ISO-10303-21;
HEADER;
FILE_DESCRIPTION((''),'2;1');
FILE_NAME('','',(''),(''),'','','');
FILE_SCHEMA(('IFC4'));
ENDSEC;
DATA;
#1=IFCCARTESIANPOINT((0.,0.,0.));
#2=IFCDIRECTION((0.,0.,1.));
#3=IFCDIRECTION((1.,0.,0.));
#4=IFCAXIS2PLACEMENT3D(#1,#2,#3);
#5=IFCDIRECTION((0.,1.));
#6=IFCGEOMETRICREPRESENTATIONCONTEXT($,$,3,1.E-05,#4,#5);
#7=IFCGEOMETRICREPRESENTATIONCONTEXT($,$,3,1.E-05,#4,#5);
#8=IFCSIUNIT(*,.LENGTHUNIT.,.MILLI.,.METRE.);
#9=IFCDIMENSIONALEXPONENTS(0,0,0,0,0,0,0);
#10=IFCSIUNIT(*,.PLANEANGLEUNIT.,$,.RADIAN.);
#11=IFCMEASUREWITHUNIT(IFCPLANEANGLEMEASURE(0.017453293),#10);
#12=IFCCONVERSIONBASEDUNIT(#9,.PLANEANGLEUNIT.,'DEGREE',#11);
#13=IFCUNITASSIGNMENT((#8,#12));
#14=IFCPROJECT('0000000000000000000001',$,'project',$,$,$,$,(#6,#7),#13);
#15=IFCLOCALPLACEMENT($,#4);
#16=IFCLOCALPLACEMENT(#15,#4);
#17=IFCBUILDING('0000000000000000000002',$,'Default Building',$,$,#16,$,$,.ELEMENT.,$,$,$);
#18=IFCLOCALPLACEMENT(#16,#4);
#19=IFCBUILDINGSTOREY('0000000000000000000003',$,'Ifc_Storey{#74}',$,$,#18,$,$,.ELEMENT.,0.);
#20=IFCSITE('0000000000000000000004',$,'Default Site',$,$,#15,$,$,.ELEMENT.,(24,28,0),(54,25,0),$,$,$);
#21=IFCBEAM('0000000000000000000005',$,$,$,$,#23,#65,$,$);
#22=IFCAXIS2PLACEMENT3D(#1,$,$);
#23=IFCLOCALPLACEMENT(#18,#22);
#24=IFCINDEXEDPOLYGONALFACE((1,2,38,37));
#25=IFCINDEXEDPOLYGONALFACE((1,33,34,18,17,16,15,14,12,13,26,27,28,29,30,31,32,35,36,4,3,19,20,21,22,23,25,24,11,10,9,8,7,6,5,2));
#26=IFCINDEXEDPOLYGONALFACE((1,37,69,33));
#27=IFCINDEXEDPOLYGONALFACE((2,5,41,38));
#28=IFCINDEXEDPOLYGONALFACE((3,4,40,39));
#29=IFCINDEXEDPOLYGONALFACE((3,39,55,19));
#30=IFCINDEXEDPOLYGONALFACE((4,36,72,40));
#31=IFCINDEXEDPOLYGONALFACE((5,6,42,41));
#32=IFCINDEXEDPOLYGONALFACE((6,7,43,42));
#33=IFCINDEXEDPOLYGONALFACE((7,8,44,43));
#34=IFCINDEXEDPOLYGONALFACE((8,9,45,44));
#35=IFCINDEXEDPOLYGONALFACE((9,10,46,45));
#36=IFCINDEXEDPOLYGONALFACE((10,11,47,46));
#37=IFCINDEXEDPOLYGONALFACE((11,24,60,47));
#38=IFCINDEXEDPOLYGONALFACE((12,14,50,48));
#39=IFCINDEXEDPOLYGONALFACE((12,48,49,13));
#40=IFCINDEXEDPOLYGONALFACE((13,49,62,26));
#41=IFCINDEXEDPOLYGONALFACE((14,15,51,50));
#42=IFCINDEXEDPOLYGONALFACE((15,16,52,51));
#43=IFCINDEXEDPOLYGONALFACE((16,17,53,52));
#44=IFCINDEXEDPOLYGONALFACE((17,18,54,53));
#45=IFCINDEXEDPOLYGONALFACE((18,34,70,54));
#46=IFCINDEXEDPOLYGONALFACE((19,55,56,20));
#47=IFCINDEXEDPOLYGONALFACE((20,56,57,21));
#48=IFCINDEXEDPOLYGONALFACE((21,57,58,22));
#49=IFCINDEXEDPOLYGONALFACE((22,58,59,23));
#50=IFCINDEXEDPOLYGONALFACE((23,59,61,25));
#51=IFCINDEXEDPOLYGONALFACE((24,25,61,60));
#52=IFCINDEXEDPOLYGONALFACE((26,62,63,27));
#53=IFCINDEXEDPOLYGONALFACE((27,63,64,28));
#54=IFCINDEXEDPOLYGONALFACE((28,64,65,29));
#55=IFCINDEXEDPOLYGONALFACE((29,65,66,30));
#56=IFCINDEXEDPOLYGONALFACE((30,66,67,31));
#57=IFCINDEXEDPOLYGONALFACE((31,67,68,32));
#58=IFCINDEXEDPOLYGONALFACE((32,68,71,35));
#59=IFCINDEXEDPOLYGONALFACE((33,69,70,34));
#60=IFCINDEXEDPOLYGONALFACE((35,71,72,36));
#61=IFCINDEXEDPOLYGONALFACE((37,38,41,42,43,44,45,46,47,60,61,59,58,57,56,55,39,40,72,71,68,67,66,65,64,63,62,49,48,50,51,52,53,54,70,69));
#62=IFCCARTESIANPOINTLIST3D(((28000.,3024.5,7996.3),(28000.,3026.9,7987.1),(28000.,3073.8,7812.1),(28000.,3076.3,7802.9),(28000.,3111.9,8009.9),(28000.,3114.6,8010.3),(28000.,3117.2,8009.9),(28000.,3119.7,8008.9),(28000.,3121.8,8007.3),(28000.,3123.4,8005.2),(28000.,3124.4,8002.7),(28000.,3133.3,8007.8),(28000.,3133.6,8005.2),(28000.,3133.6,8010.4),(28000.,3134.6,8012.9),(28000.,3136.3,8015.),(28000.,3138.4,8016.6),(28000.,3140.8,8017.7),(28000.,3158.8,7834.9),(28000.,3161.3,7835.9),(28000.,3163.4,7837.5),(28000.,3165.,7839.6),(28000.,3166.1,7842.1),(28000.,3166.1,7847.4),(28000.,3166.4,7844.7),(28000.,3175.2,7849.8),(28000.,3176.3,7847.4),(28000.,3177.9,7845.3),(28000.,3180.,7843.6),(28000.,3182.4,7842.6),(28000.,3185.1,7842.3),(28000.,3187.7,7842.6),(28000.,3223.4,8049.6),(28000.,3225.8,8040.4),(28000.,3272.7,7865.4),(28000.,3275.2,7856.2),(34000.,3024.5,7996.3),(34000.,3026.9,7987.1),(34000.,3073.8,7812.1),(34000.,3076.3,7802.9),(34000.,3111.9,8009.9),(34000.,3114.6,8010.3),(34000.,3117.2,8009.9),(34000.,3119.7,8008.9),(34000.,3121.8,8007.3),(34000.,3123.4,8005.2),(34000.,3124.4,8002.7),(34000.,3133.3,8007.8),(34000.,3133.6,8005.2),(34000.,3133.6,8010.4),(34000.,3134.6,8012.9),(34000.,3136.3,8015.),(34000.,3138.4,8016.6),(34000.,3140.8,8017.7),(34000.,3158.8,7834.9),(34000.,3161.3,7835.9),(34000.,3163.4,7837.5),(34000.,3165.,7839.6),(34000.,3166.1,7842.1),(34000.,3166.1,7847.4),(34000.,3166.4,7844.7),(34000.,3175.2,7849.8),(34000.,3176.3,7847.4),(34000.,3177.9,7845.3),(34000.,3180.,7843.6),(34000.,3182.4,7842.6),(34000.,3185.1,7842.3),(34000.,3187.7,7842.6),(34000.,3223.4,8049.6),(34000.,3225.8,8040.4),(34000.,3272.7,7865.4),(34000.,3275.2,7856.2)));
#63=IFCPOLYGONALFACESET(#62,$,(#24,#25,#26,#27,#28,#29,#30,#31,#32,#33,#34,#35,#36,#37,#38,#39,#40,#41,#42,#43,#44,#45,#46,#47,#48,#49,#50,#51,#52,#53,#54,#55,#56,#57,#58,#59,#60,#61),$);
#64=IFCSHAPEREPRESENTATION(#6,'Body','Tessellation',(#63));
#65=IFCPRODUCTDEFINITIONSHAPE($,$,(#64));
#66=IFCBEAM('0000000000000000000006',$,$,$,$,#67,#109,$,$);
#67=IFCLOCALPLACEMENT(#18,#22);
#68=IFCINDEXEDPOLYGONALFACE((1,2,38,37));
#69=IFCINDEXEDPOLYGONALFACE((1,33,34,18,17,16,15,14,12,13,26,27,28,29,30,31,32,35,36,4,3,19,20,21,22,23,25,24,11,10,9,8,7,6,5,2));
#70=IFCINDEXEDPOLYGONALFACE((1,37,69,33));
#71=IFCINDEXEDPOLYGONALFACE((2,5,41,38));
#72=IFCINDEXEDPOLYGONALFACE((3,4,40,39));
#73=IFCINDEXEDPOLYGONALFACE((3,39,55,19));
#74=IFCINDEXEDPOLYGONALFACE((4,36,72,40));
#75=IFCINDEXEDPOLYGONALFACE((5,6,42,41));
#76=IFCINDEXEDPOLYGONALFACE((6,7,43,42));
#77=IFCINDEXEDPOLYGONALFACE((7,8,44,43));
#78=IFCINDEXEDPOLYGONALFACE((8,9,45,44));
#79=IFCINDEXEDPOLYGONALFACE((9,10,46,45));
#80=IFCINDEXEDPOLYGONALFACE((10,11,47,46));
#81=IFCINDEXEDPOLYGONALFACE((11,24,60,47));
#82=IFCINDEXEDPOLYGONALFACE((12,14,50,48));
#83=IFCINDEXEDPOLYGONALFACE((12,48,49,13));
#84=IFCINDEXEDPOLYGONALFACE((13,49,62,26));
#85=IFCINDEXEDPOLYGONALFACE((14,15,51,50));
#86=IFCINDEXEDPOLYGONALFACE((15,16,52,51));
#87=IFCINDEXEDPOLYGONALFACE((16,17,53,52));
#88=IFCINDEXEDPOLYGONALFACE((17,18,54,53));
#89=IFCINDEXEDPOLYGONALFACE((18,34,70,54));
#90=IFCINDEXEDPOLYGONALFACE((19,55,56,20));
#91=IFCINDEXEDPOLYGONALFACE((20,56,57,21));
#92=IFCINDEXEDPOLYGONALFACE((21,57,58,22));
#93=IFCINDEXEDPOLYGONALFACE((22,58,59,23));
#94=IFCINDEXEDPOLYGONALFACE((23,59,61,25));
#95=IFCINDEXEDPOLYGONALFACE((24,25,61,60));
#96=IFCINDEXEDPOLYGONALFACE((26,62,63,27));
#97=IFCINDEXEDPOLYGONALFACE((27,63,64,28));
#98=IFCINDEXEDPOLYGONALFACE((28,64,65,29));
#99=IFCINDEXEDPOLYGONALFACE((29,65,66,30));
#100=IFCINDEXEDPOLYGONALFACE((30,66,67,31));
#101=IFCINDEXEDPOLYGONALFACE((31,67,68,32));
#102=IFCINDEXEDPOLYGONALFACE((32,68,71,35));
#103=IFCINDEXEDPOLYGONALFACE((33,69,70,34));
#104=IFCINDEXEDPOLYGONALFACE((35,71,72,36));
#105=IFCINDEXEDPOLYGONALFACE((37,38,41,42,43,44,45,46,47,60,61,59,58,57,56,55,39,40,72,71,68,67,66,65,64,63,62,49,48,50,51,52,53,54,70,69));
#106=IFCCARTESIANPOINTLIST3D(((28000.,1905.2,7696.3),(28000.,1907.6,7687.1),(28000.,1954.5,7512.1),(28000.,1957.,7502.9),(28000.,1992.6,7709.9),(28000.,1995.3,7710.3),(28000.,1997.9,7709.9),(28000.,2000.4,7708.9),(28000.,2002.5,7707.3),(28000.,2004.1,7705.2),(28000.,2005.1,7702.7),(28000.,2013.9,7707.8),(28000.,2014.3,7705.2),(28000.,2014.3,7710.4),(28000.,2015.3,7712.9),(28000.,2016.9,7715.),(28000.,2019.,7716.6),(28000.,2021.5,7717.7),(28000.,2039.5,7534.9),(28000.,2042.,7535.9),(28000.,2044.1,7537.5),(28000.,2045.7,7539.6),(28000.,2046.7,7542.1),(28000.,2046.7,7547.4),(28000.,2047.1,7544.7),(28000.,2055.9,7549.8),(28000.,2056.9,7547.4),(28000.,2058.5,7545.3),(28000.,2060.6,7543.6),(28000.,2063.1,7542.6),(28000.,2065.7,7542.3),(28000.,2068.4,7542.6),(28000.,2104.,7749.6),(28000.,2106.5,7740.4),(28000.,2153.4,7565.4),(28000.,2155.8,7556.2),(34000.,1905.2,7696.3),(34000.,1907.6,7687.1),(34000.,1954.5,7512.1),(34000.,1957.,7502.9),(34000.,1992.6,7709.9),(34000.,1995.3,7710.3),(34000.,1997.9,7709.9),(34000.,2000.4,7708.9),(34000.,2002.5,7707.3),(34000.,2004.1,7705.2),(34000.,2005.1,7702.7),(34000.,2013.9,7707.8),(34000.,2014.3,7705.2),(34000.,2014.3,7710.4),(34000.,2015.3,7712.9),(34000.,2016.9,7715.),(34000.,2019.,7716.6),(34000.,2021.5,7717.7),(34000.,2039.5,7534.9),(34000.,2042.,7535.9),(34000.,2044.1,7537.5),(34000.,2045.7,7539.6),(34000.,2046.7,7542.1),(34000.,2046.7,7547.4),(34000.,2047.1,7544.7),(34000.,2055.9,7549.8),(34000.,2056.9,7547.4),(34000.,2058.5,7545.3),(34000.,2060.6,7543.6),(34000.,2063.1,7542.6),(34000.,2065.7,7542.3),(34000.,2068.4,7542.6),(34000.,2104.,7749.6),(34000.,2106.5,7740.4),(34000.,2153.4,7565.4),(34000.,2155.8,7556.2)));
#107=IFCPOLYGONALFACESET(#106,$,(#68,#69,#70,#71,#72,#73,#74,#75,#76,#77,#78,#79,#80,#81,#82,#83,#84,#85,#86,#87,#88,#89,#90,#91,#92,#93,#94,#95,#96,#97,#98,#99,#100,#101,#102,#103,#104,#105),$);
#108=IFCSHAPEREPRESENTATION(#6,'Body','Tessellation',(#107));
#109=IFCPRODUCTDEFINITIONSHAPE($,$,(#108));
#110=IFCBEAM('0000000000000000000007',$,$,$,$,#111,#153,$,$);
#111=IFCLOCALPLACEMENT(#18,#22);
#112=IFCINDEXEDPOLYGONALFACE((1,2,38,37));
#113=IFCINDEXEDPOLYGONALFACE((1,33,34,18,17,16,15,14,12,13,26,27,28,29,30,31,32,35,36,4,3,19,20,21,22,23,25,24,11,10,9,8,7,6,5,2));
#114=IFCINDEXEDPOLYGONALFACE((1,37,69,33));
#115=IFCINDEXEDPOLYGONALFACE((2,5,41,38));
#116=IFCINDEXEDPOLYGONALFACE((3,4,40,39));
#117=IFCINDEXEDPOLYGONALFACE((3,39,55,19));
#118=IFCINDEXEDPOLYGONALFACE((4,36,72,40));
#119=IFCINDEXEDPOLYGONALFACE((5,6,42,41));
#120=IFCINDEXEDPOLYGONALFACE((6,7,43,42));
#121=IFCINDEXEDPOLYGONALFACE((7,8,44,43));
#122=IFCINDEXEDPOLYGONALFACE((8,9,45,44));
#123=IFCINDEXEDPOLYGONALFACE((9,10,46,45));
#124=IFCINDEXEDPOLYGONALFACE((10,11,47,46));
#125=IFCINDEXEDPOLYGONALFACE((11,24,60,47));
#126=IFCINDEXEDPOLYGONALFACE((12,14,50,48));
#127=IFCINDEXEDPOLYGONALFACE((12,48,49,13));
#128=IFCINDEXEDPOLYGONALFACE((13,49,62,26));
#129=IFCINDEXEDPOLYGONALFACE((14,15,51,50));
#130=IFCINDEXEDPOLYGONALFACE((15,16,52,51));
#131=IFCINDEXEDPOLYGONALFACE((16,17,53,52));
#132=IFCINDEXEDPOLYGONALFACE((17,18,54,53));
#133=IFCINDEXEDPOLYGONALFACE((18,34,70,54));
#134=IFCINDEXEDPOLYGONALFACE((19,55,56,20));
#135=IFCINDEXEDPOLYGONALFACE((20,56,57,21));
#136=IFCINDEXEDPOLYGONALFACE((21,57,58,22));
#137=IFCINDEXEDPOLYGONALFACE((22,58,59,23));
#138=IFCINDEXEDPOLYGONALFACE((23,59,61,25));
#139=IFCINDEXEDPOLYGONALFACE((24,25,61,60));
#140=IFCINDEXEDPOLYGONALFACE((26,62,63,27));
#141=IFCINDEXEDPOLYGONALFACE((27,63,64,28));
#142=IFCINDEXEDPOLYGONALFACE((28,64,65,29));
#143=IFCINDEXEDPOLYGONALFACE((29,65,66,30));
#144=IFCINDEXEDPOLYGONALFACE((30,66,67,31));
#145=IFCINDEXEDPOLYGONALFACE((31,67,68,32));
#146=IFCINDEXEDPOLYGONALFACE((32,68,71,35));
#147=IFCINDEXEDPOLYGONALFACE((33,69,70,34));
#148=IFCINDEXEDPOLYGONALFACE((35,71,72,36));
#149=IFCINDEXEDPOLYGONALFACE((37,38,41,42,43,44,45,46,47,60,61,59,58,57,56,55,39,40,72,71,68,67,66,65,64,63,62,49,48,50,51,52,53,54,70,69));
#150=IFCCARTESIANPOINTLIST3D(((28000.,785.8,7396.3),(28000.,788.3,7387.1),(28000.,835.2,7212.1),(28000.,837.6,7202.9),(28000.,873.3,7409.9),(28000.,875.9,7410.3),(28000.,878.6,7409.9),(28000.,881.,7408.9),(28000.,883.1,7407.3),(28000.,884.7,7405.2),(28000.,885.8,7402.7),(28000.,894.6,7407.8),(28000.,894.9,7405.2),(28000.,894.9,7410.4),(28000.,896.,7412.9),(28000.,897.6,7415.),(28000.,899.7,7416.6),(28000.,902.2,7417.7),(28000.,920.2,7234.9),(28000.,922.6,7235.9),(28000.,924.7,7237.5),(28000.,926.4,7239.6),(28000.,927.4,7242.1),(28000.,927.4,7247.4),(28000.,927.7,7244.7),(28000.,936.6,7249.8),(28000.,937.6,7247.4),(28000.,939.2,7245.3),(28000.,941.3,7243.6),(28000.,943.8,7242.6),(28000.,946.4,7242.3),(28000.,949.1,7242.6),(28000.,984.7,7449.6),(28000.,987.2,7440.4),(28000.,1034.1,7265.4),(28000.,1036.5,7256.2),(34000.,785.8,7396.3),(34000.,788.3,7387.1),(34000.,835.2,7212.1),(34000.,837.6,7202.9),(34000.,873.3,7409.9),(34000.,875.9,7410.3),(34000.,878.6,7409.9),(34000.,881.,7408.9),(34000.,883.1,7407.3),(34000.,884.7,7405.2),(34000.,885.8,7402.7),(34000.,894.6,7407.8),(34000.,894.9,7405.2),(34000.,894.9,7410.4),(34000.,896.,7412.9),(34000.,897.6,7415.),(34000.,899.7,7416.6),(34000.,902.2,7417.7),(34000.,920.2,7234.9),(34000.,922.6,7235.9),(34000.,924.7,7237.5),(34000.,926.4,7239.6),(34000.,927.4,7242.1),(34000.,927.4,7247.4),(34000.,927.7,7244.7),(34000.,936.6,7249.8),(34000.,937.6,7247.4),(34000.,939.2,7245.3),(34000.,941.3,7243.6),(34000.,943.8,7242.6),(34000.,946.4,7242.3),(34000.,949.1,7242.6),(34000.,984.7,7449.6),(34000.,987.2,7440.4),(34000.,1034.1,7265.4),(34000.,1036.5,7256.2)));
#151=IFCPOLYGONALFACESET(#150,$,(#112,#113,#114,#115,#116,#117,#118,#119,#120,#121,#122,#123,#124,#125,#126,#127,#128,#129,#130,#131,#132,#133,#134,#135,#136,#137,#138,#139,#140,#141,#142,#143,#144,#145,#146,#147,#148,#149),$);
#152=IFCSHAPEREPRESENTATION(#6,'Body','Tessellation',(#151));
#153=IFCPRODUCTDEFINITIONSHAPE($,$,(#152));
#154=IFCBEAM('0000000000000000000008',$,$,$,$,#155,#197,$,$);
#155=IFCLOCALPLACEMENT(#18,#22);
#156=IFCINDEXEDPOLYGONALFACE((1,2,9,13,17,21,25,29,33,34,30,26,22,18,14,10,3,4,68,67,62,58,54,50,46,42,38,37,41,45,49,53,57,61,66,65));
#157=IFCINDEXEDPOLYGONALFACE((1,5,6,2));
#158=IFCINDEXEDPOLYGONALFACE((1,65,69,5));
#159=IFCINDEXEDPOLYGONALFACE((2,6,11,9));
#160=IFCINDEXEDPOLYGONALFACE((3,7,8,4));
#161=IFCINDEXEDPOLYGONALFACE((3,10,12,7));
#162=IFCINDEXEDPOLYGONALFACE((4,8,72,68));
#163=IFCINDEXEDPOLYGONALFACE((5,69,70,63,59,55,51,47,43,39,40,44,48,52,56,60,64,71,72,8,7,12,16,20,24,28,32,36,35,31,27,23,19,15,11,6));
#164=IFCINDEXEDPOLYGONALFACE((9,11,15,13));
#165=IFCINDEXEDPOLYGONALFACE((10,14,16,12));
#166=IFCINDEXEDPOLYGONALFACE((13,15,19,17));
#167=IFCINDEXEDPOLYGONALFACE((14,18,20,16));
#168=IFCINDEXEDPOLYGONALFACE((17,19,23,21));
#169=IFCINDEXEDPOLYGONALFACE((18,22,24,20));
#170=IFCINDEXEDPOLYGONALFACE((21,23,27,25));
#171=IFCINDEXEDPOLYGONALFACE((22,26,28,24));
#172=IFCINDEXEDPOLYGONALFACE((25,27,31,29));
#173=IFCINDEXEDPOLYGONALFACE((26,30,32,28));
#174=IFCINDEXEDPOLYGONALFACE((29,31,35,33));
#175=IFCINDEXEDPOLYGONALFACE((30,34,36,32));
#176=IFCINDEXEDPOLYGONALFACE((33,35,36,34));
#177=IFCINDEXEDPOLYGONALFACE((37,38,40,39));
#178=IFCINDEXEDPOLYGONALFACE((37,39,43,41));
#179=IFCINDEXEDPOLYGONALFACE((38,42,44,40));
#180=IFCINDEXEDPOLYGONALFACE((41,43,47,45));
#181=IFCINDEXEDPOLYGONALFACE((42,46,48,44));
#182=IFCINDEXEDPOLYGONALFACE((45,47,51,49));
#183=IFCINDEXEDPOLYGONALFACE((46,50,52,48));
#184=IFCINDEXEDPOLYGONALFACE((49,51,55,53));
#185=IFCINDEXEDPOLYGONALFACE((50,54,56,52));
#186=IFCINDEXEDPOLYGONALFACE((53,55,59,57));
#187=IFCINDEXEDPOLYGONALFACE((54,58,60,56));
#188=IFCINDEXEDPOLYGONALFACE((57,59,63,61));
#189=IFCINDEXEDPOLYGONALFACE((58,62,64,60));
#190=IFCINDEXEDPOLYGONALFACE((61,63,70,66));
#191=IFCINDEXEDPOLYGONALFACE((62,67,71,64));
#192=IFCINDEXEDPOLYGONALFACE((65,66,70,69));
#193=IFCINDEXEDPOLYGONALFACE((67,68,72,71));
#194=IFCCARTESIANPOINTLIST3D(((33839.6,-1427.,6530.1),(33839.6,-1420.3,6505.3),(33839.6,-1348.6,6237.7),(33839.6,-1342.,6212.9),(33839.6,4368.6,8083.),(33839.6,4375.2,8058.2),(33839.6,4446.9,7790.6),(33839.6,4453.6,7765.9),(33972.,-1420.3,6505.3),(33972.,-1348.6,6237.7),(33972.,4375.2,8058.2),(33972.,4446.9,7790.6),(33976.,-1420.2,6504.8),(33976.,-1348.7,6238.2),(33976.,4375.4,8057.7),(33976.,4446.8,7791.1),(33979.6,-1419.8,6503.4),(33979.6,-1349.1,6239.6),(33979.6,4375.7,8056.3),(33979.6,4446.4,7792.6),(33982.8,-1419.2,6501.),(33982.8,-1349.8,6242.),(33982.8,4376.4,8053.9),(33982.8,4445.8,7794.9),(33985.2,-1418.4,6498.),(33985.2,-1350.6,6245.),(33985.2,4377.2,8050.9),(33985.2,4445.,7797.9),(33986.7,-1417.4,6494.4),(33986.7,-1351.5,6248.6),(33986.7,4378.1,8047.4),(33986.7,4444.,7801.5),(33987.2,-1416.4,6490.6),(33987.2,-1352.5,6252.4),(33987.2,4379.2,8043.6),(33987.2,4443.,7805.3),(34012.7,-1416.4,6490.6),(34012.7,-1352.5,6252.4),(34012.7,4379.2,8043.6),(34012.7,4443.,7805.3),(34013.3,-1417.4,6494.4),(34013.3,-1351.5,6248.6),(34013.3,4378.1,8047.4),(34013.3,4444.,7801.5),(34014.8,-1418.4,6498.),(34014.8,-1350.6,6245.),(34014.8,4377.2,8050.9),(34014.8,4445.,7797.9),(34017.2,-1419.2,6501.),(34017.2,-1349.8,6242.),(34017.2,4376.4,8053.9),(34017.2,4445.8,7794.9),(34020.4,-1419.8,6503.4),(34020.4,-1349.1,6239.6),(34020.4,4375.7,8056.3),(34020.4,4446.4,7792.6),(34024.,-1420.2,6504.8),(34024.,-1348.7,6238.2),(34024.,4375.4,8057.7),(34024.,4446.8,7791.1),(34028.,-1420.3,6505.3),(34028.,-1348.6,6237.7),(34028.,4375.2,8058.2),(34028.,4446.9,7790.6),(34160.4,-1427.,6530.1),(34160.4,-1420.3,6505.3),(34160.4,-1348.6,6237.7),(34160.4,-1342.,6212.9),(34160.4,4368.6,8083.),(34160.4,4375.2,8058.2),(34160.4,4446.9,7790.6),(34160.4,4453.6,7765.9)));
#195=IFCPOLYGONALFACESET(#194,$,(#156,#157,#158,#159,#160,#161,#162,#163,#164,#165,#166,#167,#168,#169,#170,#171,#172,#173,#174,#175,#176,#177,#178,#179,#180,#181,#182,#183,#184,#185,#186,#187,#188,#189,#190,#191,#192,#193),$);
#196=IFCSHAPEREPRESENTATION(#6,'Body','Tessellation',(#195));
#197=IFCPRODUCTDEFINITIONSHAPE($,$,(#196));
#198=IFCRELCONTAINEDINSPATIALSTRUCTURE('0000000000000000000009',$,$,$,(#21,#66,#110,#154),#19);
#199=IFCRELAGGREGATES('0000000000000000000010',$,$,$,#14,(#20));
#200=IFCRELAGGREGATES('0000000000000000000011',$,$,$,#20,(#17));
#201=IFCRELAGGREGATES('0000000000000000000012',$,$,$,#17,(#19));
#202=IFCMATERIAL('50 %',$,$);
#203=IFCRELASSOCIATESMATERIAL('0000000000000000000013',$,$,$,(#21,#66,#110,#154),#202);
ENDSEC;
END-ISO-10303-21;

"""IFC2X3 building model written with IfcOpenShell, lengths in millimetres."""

from ifc_helpers import new_model, entity, si_unit, converted_unit, direction, frame, origin_with_axes, origin_2d_with_axis, place, context, project, spatial, i_section, extrude, material, element, save


model = new_model("IFC2X3")

# Units and contexts
context_of_model_1 = context(None, 3, precision=1e-05, world=origin_with_axes(), true_north=direction((0.0, 1.0)))
context_of_model_2 = context(None, 3, precision=1e-05, world=origin_with_axes(), true_north=direction((0.0, 1.0)))
ifc_project = project(units=[si_unit("LENGTHUNIT", "METRE", prefix="MILLI"), converted_unit("PLANEANGLEUNIT", "DEGREE", entity("IfcPlaneAngleMeasure", 0.017453293), si_unit("PLANEANGLEUNIT", "RADIAN"), dimensions=[0, 0, 0, 0, 0, 0, 0])], contexts=[context_of_model_1, context_of_model_2])

# Site, building, storey
site_placement = place(None, origin_with_axes())
site = spatial("IfcSite", under=ifc_project, at=site_placement, Name="Default Site", CompositionType="ELEMENT", RefLatitude=(24, 28, 0), RefLongitude=(54, 25, 0))
building_placement = place(site_placement, origin_with_axes())
building = spatial("IfcBuilding", under=site, at=building_placement, Name="Default Building", CompositionType="ELEMENT")
storey_placement = place(building_placement, origin_with_axes())
storey = spatial("IfcBuildingStorey", under=building, at=storey_placement, Name="Ifc_Storey{#74}", CompositionType="ELEMENT", Elevation=0.0)

# Shared definitions
ifc_material_1 = material(Name="50 %")

# Beams
for number, where, z_axis, x_axis in (
    (1, (28000.0, 3149.8, 7926.3), (0.0, -0.258819, 0.965926), (-1.0, 0.0, 0.0)),
    (2, (28000.0, 2030.5, 7626.3), (0.0, -0.258819, 0.965926), (-1.0, 0.0, 0.0)),
    (3, (28000.0, 911.2, 7326.3), (0.0, -0.258819, 0.965926), (-1.0, 0.0, 0.0)),
):
    element("IfcBeam", number, at=place(storey_placement, frame(where, z_axis=z_axis, x_axis=x_axis)), inside=storey, material=ifc_material_1, context=context_of_model_1, shape_type="SweptSolid", body=[
        extrude(i_section(OverallWidth=205.9, OverallDepth=200.2, WebThickness=9.5, FlangeThickness=9.5, FilletRadius=10.2, at=origin_2d_with_axis()), frame((0.0, 0.0, 0.0), z_axis=(-1.0, 0.0, 0.0), x_axis=(0.0, 1.0, 0.0)), (0.0, 0.0, 1.0), 6000.0),
    ])
for number, where, z_axis, x_axis in (
    (4, (34000.0, -1384.5, 6371.5), (0.0, 0.0, 1.0), (0.0, -1.0, 0.0)),
):
    element("IfcBeam", number, at=place(storey_placement, frame(where, z_axis=z_axis, x_axis=x_axis)), inside=storey, material=ifc_material_1, context=context_of_model_1, shape_type="SweptSolid", body=[
        extrude(i_section(OverallWidth=320.9, OverallDepth=328.3, WebThickness=25.5, FlangeThickness=25.6, FilletRadius=15.2, at=origin_2d_with_axis()), frame((0.0, 0.0, 0.0), z_axis=(-0.965926, 0.0, 0.258819), x_axis=(0.0, 1.0, 0.0)), (0.0, 0.0, 1.0), 6000.0),
    ])

save(model, "model.ifc")
